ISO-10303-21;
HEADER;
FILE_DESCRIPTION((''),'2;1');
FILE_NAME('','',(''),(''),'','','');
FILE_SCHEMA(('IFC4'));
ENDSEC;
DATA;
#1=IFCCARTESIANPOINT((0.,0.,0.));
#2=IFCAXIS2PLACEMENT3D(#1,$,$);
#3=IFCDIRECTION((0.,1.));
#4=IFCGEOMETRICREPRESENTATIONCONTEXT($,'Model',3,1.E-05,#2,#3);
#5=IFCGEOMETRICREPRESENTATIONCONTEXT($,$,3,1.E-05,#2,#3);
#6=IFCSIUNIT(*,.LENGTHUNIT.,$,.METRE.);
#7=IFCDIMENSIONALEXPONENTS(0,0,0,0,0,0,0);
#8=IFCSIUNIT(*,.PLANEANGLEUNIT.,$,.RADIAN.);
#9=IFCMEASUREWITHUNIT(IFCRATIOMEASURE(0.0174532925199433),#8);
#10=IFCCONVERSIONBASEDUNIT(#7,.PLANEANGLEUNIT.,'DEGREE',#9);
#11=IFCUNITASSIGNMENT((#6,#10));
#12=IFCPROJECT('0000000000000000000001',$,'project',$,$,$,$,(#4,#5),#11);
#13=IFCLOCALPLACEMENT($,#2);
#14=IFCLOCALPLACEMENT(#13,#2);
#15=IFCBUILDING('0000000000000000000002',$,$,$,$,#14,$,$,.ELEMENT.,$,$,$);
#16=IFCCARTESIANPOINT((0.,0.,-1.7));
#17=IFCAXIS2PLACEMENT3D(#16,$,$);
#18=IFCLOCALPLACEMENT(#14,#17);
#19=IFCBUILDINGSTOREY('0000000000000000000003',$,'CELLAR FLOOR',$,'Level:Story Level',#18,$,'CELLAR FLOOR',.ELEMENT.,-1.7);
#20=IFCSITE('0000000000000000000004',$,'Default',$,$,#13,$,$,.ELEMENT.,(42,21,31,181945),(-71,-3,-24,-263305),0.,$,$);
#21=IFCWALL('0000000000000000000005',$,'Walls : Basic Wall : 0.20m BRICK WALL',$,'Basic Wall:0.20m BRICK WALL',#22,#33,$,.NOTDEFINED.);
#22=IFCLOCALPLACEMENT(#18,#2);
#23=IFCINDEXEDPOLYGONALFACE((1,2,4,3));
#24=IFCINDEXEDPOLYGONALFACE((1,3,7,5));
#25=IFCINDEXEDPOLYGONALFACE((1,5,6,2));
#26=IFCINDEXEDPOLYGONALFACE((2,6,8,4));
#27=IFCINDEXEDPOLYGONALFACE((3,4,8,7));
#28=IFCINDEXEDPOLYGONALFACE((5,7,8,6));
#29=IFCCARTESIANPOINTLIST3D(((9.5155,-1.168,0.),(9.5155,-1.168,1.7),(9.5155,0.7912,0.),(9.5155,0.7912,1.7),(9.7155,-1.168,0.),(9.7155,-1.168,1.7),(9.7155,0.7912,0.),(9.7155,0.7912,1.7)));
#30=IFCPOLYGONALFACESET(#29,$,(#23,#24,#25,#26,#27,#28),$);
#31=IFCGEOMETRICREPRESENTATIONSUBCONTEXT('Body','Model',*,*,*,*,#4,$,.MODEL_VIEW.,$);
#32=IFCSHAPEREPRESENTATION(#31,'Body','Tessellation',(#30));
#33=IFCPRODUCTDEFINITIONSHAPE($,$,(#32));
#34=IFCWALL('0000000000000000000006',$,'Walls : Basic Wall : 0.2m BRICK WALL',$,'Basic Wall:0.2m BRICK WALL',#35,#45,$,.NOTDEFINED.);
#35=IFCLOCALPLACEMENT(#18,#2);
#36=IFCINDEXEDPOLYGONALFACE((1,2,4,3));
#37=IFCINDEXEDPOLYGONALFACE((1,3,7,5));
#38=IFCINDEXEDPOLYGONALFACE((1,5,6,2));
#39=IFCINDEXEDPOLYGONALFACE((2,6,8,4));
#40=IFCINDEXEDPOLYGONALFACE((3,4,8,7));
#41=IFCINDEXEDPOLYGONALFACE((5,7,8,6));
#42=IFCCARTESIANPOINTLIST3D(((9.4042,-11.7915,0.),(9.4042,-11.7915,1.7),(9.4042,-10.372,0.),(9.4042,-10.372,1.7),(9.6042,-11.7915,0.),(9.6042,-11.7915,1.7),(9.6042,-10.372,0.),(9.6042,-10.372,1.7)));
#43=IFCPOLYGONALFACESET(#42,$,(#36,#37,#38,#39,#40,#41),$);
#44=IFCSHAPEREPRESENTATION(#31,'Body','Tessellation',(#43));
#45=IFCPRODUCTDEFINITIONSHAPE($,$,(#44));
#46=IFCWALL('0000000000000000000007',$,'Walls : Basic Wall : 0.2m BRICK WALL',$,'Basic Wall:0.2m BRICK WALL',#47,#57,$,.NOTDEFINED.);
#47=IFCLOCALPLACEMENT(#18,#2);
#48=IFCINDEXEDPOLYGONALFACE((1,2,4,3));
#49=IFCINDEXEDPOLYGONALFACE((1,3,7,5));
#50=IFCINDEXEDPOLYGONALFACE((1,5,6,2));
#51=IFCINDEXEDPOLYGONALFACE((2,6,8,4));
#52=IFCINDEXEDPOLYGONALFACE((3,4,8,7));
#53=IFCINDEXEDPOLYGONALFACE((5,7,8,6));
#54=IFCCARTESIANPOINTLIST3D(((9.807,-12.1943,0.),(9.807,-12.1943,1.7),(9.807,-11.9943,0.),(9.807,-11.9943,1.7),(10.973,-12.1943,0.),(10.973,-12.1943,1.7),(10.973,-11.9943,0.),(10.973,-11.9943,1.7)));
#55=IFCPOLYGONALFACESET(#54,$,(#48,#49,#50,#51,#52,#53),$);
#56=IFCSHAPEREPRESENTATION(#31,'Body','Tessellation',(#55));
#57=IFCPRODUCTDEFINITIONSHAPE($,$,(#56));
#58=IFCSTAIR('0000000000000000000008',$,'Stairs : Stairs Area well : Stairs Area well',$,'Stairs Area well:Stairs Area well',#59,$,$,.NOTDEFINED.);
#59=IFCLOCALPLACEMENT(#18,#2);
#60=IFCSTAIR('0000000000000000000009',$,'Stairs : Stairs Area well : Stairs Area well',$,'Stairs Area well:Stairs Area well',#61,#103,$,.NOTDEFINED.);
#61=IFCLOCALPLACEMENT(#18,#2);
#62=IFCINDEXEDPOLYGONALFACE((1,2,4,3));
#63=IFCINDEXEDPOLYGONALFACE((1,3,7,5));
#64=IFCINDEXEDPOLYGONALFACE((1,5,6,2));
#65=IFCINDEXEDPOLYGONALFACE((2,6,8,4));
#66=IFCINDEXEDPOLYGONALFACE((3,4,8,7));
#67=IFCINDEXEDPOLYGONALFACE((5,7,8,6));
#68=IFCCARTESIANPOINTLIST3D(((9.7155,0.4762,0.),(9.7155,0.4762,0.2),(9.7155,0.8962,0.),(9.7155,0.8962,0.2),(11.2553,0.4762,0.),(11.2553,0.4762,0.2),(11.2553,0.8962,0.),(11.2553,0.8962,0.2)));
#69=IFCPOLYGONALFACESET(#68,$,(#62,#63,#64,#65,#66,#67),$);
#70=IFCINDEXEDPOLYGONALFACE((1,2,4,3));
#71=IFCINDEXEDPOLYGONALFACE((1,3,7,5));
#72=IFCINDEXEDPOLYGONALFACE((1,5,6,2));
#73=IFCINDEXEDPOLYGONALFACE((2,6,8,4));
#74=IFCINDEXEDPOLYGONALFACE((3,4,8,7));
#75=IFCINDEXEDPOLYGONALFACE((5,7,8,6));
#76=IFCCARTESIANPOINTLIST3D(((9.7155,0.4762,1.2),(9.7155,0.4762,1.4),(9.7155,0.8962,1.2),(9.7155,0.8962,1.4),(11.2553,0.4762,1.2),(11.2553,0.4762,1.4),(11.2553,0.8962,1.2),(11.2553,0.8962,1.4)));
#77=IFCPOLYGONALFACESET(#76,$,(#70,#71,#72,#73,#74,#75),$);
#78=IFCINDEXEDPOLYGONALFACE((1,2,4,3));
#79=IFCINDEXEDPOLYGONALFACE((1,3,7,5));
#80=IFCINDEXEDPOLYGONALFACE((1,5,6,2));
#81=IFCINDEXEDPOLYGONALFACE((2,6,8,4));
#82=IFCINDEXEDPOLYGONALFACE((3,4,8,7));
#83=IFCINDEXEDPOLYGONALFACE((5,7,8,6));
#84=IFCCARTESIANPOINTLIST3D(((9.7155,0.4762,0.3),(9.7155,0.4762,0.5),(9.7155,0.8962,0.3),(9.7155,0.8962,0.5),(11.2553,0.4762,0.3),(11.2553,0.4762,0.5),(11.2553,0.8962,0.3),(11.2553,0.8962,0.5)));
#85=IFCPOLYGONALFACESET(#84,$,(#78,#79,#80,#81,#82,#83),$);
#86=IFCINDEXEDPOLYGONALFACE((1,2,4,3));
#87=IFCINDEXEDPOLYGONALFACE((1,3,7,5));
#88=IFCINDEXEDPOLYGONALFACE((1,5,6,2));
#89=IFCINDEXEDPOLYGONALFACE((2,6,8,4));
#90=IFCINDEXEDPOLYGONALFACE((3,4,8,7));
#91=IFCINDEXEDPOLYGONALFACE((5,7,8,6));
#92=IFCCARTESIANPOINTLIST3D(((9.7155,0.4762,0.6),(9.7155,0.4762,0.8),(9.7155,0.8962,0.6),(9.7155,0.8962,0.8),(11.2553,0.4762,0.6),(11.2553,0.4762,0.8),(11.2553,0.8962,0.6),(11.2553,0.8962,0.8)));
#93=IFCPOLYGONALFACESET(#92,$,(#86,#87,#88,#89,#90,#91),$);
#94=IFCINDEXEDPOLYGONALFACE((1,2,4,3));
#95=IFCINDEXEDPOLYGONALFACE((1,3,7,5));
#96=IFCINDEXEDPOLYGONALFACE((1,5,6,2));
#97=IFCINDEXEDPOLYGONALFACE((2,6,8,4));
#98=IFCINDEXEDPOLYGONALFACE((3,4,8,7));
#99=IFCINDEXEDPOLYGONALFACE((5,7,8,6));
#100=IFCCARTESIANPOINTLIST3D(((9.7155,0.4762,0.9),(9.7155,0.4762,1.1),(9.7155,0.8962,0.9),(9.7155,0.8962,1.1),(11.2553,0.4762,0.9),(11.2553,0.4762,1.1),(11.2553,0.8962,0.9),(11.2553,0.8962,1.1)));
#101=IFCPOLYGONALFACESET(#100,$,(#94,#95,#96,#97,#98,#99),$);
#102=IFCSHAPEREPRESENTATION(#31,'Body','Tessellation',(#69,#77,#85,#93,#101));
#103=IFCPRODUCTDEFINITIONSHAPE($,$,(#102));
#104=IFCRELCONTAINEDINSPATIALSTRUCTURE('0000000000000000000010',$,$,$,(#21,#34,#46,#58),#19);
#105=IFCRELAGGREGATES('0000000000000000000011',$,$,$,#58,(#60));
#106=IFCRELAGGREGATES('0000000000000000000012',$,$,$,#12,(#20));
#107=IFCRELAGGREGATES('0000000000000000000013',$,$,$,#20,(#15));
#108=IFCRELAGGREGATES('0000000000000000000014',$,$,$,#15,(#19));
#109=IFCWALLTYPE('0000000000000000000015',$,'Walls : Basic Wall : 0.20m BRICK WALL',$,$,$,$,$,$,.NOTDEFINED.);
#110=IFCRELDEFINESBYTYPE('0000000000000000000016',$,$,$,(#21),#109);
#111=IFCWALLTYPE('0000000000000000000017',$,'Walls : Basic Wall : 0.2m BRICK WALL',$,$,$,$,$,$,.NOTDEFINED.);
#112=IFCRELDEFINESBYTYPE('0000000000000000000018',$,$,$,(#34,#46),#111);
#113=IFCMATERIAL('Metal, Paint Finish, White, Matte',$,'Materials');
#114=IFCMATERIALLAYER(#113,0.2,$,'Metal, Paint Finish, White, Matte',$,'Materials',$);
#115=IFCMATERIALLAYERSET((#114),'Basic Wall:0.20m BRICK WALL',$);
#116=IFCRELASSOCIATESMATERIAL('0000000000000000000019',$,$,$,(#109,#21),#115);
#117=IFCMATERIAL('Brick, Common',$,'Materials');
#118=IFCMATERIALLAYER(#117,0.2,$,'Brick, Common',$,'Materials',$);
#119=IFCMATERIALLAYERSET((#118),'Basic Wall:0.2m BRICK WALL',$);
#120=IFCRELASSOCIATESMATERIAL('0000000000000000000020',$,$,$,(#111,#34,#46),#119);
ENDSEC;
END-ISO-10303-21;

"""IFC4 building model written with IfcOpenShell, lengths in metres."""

from ifc_helpers import new_model, entity, si_unit, converted_unit, direction, frame, frame_2d, origin, place, context, subcontext, project, spatial, rectangle, extrude, material, layer, layer_set, layer_usage, type_object, element, aggregate, save


model = new_model("IFC4")

# Units and contexts
model_context = context("Model", 3, precision=1e-05, world=origin(), true_north=direction((0.0, 1.0)))
context_of_model = context(None, 3, precision=1e-05, world=origin(), true_north=direction((0.0, 1.0)))
body_context = subcontext(model_context, "Body", "Model", "MODEL_VIEW")
ifc_project = project(units=[si_unit("LENGTHUNIT", "METRE"), converted_unit("PLANEANGLEUNIT", "DEGREE", entity("IfcRatioMeasure", 0.0174532925199433), si_unit("PLANEANGLEUNIT", "RADIAN"), dimensions=[0, 0, 0, 0, 0, 0, 0])], contexts=[model_context, context_of_model])

# Site, building, storey
site_placement = place(None, origin())
site = spatial("IfcSite", under=ifc_project, at=site_placement, Name="Default", CompositionType="ELEMENT", RefLatitude=(42, 21, 31, 181945), RefLongitude=(-71, -3, -24, -263305), RefElevation=0.0)
building_placement = place(site_placement, origin())
building = spatial("IfcBuilding", under=site, at=building_placement, CompositionType="ELEMENT")
storey_placement = place(building_placement, frame((0.0, 0.0, -1.7)))
storey = spatial("IfcBuildingStorey", under=building, at=storey_placement, Name="CELLAR FLOOR", ObjectType="Level:Story Level", LongName="CELLAR FLOOR", CompositionType="ELEMENT", Elevation=-1.7)

# Shared definitions
ifc_material_1 = material(Name="Brick, Common", Category="Materials")

# Shared definitions
ifc_material_2 = material(Name="Metal, Paint Finish, White, Matte", Category="Materials")

# Walls
ifc_layer_1 = layer(ifc_material_2, 0.2, Name="Metal, Paint Finish, White, Matte", Category="Materials")
ifc_layer_set_1 = layer_set([ifc_layer_1], Name="Basic Wall:0.20m BRICK WALL")
ifc_layer_usage_1 = layer_usage(ifc_layer_set_1, "AXIS2", "NEGATIVE", 0.1)
wall_type_1 = type_object("IfcWallType", Name="Walls : Basic Wall : 0.20m BRICK WALL", PredefinedType="NOTDEFINED", material=ifc_layer_set_1)
wall_1_placement = place(storey_placement, frame((9.6155, 0.7912, 0.0), z_axis=(0.0, 0.0, 1.0), x_axis=(0.0, -1.0, 0.0)))
element("IfcWall", 1, at=wall_1_placement, inside=storey, type_object=wall_type_1, material=ifc_layer_usage_1, Name="Walls : Basic Wall : 0.20m BRICK WALL", ObjectType="Basic Wall:0.20m BRICK WALL", PredefinedType="NOTDEFINED", context=body_context, shape_type="SweptSolid", body=[
    extrude(rectangle(XDim=1.9592, YDim=0.2, at=frame_2d((0.9796, 0.0), x_axis=(-1.0, 0.0))), origin(), (0.0, 0.0, 1.0), 1.7),
])
ifc_layer_2 = layer(ifc_material_1, 0.2, Name="Brick, Common", Category="Materials")
ifc_layer_set_2 = layer_set([ifc_layer_2], Name="Basic Wall:0.2m BRICK WALL")
ifc_layer_usage_2 = layer_usage(ifc_layer_set_2, "AXIS2", "NEGATIVE", 0.1)
wall_type_2 = type_object("IfcWallType", Name="Walls : Basic Wall : 0.2m BRICK WALL", PredefinedType="NOTDEFINED", material=ifc_layer_set_2)
wall_2_placement = place(storey_placement, frame((9.5042, -10.372, 0.0), z_axis=(0.0, 0.0, 1.0), x_axis=(0.0, -1.0, 0.0)))
element("IfcWall", 2, at=wall_2_placement, inside=storey, type_object=wall_type_2, material=ifc_layer_usage_2, Name="Walls : Basic Wall : 0.2m BRICK WALL", ObjectType="Basic Wall:0.2m BRICK WALL", PredefinedType="NOTDEFINED", context=body_context, shape_type="SweptSolid", body=[
    extrude(rectangle(XDim=1.4195, YDim=0.2, at=frame_2d((0.7097, 0.0), x_axis=(-1.0, 0.0))), origin(), (0.0, 0.0, 1.0), 1.7),
])
ifc_layer_usage_3 = layer_usage(ifc_layer_set_2, "AXIS2", "NEGATIVE", 0.1)
wall_3_placement = place(storey_placement, frame((9.807, -12.0943, 0.0)))
element("IfcWall", 3, at=wall_3_placement, inside=storey, type_object=wall_type_2, material=ifc_layer_usage_3, Name="Walls : Basic Wall : 0.2m BRICK WALL", ObjectType="Basic Wall:0.2m BRICK WALL", PredefinedType="NOTDEFINED", context=body_context, shape_type="SweptSolid", body=[
    extrude(rectangle(XDim=1.166, YDim=0.2, at=frame_2d((0.583, 0.0), x_axis=(-1.0, 0.0))), origin(), (0.0, 0.0, 1.0), 1.7),
])

# Stairs
stair_1_placement = place(storey_placement, frame((9.7155, 0.4762, 0.0)))
stair_1 = element("IfcStair", 4, at=stair_1_placement, inside=storey, Name="Stairs : Stairs Area well : Stairs Area well", ObjectType="Stairs Area well:Stairs Area well", PredefinedType="NOTDEFINED")
stair_2_placement = place(stair_1_placement, origin())
stair_2 = element("IfcStair", 5, at=stair_2_placement, Name="Stairs : Stairs Area well : Stairs Area well", ObjectType="Stairs Area well:Stairs Area well", PredefinedType="NOTDEFINED", context=body_context, shape_type="SweptSolid", body=[
    extrude(rectangle(XDim=1.5398, YDim=0.42, at=frame_2d((0.0, 0.0), x_axis=(1.0, 0.0))), frame((0.7699, 0.21, 0.0), z_axis=(0.0, 0.0, 1.0), x_axis=(-1.0, 0.0, 0.0)), (0.0, 0.0, 1.0), 0.2),
    extrude(rectangle(XDim=1.5398, YDim=0.42, at=frame_2d((0.0, 0.0), x_axis=(1.0, 0.0))), frame((0.7699, 0.21, 1.2), z_axis=(0.0, 0.0, 1.0), x_axis=(-1.0, 0.0, 0.0)), (0.0, 0.0, 1.0), 0.2),
    extrude(rectangle(XDim=1.5398, YDim=0.42, at=frame_2d((0.0, 0.0), x_axis=(1.0, 0.0))), frame((0.7699, 0.21, 0.3), z_axis=(0.0, 0.0, 1.0), x_axis=(-1.0, 0.0, 0.0)), (0.0, 0.0, 1.0), 0.2),
    extrude(rectangle(XDim=1.5398, YDim=0.42, at=frame_2d((0.0, 0.0), x_axis=(1.0, 0.0))), frame((0.7699, 0.21, 0.6), z_axis=(0.0, 0.0, 1.0), x_axis=(-1.0, 0.0, 0.0)), (0.0, 0.0, 1.0), 0.2),
    extrude(rectangle(XDim=1.5398, YDim=0.42, at=frame_2d((0.0, 0.0), x_axis=(1.0, 0.0))), frame((0.7699, 0.21, 0.9), z_axis=(0.0, 0.0, 1.0), x_axis=(-1.0, 0.0, 0.0)), (0.0, 0.0, 1.0), 0.2),
])
aggregate(stair_1, [stair_2])

save(model, "model.ifc")
